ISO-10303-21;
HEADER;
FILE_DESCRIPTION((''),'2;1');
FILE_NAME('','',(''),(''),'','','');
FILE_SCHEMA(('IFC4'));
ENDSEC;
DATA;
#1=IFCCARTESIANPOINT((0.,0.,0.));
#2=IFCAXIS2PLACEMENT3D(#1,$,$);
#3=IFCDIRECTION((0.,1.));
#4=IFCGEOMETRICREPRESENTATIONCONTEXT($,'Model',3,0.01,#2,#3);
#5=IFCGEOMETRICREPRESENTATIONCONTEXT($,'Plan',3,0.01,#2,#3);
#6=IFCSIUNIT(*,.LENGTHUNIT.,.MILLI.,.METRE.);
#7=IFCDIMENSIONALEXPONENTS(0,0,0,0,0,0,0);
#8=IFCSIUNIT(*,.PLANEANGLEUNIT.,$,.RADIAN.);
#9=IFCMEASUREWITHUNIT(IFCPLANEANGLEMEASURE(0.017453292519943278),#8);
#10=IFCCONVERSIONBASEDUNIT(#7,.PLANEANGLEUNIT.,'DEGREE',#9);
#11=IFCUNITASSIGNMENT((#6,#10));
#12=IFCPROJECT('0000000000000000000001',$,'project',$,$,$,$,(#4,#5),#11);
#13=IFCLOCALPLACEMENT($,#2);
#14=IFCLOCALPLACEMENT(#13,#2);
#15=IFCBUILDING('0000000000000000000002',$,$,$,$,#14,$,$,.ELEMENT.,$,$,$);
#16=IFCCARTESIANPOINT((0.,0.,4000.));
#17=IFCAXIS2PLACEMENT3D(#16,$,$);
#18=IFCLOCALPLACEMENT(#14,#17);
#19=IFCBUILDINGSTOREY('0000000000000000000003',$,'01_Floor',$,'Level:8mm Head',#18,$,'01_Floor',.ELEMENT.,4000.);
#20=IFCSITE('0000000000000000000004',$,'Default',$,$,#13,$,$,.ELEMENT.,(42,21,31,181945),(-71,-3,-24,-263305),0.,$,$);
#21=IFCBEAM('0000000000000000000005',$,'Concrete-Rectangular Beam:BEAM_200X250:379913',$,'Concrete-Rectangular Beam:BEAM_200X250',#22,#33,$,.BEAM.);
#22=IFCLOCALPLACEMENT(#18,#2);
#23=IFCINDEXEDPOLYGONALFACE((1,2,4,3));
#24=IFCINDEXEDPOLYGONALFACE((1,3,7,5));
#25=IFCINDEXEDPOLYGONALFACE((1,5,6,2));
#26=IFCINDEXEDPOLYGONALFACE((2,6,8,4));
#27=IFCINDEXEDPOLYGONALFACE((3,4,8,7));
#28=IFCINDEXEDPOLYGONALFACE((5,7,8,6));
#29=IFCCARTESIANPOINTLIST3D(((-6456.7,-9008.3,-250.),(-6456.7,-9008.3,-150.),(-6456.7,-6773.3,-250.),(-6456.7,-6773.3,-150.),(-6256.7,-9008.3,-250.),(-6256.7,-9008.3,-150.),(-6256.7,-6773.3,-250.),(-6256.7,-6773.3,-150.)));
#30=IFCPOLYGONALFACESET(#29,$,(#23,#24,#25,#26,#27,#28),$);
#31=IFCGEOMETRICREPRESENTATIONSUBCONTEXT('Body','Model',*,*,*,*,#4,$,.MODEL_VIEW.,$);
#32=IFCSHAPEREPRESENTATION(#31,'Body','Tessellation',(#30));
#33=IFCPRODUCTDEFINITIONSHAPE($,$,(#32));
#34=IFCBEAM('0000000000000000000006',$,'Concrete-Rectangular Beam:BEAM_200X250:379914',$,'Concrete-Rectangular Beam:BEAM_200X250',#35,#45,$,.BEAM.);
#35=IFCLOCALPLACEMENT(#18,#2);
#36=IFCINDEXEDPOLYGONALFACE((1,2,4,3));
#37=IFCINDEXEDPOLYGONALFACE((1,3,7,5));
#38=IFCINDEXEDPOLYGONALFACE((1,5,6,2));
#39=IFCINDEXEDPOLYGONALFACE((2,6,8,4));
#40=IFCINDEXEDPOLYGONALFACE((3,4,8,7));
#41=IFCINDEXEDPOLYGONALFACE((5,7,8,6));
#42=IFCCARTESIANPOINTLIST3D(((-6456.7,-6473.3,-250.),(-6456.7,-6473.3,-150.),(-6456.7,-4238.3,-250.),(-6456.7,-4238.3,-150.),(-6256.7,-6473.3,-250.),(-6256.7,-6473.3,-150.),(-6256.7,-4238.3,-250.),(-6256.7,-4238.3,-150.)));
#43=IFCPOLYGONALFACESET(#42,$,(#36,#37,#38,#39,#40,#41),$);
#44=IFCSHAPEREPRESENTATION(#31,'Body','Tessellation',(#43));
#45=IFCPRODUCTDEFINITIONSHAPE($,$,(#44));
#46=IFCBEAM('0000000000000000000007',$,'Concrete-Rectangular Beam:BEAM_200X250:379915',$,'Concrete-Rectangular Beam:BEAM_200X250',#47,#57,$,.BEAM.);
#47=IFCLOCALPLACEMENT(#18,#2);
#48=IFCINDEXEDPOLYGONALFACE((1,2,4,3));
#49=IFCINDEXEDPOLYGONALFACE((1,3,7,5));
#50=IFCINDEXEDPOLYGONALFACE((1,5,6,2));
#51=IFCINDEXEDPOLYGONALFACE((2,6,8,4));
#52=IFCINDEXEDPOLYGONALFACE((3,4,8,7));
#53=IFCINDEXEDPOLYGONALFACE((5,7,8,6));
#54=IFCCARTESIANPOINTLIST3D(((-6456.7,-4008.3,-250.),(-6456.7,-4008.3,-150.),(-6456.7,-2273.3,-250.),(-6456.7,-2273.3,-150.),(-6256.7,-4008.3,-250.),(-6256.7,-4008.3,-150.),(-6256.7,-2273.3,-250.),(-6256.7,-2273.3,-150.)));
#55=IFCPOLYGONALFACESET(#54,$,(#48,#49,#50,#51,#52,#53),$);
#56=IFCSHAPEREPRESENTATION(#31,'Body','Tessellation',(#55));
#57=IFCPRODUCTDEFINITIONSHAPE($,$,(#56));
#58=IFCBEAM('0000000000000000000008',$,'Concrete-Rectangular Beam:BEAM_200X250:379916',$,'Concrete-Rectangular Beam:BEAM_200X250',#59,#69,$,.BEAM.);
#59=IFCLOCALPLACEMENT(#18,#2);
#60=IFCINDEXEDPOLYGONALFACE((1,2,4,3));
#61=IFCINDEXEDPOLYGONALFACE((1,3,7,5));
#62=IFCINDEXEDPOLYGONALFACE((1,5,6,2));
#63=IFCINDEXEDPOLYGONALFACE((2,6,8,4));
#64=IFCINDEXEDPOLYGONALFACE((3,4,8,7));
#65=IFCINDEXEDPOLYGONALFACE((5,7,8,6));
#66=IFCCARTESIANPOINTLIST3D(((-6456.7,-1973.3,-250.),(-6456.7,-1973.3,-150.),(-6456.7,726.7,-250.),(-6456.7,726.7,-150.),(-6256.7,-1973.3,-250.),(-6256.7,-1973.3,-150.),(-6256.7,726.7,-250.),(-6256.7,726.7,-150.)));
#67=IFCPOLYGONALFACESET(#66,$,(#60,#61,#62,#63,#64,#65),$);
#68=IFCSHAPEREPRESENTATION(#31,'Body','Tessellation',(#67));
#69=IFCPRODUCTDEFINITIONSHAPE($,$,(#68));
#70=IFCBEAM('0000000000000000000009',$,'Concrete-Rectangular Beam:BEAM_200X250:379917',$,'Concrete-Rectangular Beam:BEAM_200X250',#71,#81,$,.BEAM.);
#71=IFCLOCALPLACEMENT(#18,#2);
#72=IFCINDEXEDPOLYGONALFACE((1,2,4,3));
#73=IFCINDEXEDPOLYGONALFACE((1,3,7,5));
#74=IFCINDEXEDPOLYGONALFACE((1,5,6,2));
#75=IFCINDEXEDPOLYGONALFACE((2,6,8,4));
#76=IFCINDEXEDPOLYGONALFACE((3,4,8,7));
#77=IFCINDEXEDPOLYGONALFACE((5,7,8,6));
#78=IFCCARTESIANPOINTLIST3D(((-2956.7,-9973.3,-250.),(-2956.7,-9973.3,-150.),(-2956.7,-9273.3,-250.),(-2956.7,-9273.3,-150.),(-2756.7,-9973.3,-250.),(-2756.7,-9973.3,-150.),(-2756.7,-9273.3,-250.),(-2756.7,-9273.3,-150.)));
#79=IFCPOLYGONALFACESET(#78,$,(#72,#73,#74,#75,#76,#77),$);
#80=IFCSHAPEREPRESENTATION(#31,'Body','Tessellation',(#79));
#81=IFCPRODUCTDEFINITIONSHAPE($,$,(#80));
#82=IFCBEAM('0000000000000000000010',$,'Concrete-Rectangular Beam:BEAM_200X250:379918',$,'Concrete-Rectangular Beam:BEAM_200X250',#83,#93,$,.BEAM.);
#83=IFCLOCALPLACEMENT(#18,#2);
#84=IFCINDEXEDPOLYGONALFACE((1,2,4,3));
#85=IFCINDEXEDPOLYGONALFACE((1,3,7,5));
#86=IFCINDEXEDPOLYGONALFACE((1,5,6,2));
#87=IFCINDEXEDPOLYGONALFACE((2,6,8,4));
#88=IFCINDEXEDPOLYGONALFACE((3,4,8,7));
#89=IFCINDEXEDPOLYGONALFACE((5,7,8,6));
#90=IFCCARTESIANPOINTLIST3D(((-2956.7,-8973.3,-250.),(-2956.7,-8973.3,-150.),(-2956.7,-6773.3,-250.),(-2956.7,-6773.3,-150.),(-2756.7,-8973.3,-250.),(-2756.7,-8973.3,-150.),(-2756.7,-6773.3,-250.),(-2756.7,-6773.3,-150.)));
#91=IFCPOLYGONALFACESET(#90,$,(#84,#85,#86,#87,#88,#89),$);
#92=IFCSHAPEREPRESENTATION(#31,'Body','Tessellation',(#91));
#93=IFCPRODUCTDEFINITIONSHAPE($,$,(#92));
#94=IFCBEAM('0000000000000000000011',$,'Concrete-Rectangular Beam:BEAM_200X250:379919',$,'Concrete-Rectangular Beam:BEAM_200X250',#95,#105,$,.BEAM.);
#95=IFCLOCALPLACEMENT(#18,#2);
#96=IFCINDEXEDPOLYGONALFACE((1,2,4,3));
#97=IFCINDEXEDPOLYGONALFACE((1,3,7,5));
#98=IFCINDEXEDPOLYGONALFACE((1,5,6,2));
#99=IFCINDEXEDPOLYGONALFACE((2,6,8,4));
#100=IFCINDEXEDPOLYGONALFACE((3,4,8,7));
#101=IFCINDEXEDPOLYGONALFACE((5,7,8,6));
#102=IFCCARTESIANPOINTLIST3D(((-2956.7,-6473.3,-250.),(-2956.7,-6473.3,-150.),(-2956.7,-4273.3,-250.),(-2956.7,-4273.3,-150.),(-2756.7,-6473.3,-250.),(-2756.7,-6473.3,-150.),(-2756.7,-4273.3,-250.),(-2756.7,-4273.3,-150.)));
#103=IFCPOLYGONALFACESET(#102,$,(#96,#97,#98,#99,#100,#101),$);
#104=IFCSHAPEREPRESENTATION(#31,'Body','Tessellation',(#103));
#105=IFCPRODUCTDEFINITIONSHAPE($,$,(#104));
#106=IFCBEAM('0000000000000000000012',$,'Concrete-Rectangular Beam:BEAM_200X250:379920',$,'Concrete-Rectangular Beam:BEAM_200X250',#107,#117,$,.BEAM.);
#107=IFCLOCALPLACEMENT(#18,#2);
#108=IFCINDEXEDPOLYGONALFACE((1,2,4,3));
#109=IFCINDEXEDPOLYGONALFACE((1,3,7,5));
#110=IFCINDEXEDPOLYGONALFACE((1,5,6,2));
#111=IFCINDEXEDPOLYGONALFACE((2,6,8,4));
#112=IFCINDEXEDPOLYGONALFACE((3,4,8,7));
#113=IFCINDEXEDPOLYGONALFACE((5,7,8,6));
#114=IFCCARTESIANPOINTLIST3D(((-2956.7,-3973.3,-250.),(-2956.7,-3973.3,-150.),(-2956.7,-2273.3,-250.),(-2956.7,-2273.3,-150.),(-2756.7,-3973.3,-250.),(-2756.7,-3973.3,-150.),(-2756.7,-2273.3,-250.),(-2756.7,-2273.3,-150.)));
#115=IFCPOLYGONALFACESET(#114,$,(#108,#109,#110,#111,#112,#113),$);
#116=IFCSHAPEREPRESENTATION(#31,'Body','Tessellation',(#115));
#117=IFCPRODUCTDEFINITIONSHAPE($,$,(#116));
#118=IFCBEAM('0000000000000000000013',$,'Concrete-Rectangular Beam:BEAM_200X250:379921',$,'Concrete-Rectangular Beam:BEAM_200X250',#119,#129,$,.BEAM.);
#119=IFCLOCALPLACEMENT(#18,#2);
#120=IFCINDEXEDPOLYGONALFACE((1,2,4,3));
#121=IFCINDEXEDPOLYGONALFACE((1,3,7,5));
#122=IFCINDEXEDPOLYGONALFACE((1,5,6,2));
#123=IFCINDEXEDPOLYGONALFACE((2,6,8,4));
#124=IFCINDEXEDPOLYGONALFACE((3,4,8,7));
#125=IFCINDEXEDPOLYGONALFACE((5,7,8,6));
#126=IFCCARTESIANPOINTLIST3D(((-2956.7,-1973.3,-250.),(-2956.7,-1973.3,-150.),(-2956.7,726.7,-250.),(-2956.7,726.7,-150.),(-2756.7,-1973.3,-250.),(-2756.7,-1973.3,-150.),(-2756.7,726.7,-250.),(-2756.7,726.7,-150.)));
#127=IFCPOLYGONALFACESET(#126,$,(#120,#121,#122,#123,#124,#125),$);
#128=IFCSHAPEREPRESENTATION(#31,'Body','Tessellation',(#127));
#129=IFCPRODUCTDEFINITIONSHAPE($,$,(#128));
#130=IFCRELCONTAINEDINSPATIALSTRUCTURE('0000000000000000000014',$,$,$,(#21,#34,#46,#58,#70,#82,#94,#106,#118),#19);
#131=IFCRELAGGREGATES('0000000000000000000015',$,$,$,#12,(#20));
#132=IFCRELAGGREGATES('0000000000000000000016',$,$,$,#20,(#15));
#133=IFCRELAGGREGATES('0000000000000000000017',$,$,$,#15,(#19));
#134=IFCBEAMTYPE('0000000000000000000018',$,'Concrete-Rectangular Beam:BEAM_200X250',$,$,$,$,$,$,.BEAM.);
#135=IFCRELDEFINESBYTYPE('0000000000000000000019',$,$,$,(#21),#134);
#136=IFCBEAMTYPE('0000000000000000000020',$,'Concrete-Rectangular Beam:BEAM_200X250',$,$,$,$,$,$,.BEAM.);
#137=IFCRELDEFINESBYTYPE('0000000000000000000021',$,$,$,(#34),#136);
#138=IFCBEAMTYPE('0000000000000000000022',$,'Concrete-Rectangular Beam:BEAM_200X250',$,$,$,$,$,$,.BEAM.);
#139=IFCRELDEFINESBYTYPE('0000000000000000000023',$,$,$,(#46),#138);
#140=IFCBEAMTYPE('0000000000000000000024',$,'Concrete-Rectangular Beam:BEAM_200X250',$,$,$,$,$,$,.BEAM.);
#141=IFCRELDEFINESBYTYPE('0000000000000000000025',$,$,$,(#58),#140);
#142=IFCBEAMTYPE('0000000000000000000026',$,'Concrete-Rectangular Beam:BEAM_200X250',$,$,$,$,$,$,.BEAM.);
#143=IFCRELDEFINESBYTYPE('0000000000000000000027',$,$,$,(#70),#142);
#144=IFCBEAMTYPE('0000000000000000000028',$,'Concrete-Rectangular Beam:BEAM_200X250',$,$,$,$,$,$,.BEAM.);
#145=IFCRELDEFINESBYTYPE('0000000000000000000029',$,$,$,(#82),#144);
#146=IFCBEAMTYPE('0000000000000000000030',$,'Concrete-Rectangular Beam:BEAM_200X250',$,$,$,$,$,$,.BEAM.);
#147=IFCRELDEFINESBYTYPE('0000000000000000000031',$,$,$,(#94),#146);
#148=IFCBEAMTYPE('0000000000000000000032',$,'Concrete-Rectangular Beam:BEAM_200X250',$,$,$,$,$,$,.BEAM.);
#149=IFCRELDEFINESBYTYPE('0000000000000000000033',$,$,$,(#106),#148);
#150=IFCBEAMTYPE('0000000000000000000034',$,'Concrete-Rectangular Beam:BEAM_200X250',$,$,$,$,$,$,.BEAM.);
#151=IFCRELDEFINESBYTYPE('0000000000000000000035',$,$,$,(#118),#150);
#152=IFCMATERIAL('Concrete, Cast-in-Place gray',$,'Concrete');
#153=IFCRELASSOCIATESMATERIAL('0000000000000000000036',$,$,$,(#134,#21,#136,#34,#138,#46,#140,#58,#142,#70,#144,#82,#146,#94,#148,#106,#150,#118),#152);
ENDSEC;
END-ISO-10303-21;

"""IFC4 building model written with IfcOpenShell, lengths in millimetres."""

from ifc_helpers import new_model, entity, si_unit, converted_unit, direction, frame, origin, place, context, subcontext, project, spatial, indexed_curve, outline, extrude, source, transform, mapped, material, type_object, type_shapes, element, save


model = new_model("IFC4")

# Units and contexts
model_context = context("Model", 3, precision=0.01, world=origin(), true_north=direction((0.0, 1.0)))
plan_context = context("Plan", 3, precision=0.01, world=origin(), true_north=direction((0.0, 1.0)))
body_context = subcontext(model_context, "Body", "Model", "MODEL_VIEW")
ifc_project = project(units=[si_unit("LENGTHUNIT", "METRE", prefix="MILLI"), converted_unit("PLANEANGLEUNIT", "DEGREE", entity("IfcPlaneAngleMeasure", 0.017453292519943278), si_unit("PLANEANGLEUNIT", "RADIAN"), dimensions=[0, 0, 0, 0, 0, 0, 0])], contexts=[model_context, plan_context])

# Site, building, storey
site_placement = place(None, origin())
site = spatial("IfcSite", under=ifc_project, at=site_placement, Name="Default", CompositionType="ELEMENT", RefLatitude=(42, 21, 31, 181945), RefLongitude=(-71, -3, -24, -263305), RefElevation=0.0)
building_placement = place(site_placement, origin())
building = spatial("IfcBuilding", under=site, at=building_placement, CompositionType="ELEMENT")
storey_placement = place(building_placement, frame((0.0, 0.0, 4000.0)))
storey = spatial("IfcBuildingStorey", under=building, at=storey_placement, Name="01_Floor", ObjectType="Level:8mm Head", LongName="01_Floor", CompositionType="ELEMENT", Elevation=4000.0)

# Shared definitions
ifc_material = material(Name="Concrete, Cast-in-Place gray", Category="Concrete")

# Beams
beam_type_1 = type_object("IfcBeamType", Name="Concrete-Rectangular Beam:BEAM_200X250", PredefinedType="BEAM", material=ifc_material)
shared_shape_1 = source(origin(), body_context, "Body", "SweptSolid", [
    extrude(outline(indexed_curve([(-100.0, -50.0), (100.0, -50.0), (100.0, 50.0), (-100.0, 50.0), (-100.0, -50.0)], self_intersect=False)), frame((-6356.7, -9008.3, 3800.0), z_axis=(0.0, 1.0, 0.0), x_axis=(-1.0, 0.0, 0.0)), (0.0, 0.0, 1.0), 2235.0),
])
type_shapes(beam_type_1, [shared_shape_1])
beam_1_placement = place(storey_placement, frame((0.0, 0.0, -4000.0)))
element("IfcBeam", 1, at=beam_1_placement, inside=storey, type_object=beam_type_1, material=ifc_material, Name="Concrete-Rectangular Beam:BEAM_200X250:379913", ObjectType="Concrete-Rectangular Beam:BEAM_200X250", PredefinedType="BEAM", context=body_context, shape_type="MappedRepresentation", body=[
    mapped(shared_shape_1, transform((0.0, 0.0, 0.0), scale=1.0)),
])
beam_type_2 = type_object("IfcBeamType", Name="Concrete-Rectangular Beam:BEAM_200X250", PredefinedType="BEAM", material=ifc_material)
shared_shape_2 = source(origin(), body_context, "Body", "SweptSolid", [
    extrude(outline(indexed_curve([(-100.0, -50.0), (100.0, -50.0), (100.0, 50.0), (-100.0, 50.0), (-100.0, -50.0)], self_intersect=False)), frame((-6356.7, -6473.3, 3800.0), z_axis=(0.0, 1.0, 0.0), x_axis=(-1.0, 0.0, 0.0)), (0.0, 0.0, 1.0), 2235.0),
])
type_shapes(beam_type_2, [shared_shape_2])
beam_2_placement = place(storey_placement, frame((0.0, 0.0, -4000.0)))
element("IfcBeam", 2, at=beam_2_placement, inside=storey, type_object=beam_type_2, material=ifc_material, Name="Concrete-Rectangular Beam:BEAM_200X250:379914", ObjectType="Concrete-Rectangular Beam:BEAM_200X250", PredefinedType="BEAM", context=body_context, shape_type="MappedRepresentation", body=[
    mapped(shared_shape_2, transform((0.0, 0.0, 0.0), scale=1.0)),
])
beam_type_3 = type_object("IfcBeamType", Name="Concrete-Rectangular Beam:BEAM_200X250", PredefinedType="BEAM", material=ifc_material)
shared_shape_3 = source(origin(), body_context, "Body", "SweptSolid", [
    extrude(outline(indexed_curve([(-100.0, -50.0), (100.0, -50.0), (100.0, 50.0), (-100.0, 50.0), (-100.0, -50.0)], self_intersect=False)), frame((-6356.7, -4008.3, 3800.0), z_axis=(0.0, 1.0, 0.0), x_axis=(-1.0, 0.0, 0.0)), (0.0, 0.0, 1.0), 1735.0),
])
type_shapes(beam_type_3, [shared_shape_3])
beam_3_placement = place(storey_placement, frame((0.0, 0.0, -4000.0)))
element("IfcBeam", 3, at=beam_3_placement, inside=storey, type_object=beam_type_3, material=ifc_material, Name="Concrete-Rectangular Beam:BEAM_200X250:379915", ObjectType="Concrete-Rectangular Beam:BEAM_200X250", PredefinedType="BEAM", context=body_context, shape_type="MappedRepresentation", body=[
    mapped(shared_shape_3, transform((0.0, 0.0, 0.0), scale=1.0)),
])
beam_type_4 = type_object("IfcBeamType", Name="Concrete-Rectangular Beam:BEAM_200X250", PredefinedType="BEAM", material=ifc_material)
shared_shape_4 = source(origin(), body_context, "Body", "SweptSolid", [
    extrude(outline(indexed_curve([(-100.0, -50.0), (100.0, -50.0), (100.0, 50.0), (-100.0, 50.0), (-100.0, -50.0)], self_intersect=False)), frame((-6356.7, -1973.3, 3800.0), z_axis=(0.0, 1.0, 0.0), x_axis=(-1.0, 0.0, 0.0)), (0.0, 0.0, 1.0), 2700.0),
])
type_shapes(beam_type_4, [shared_shape_4])
beam_4_placement = place(storey_placement, frame((0.0, 0.0, -4000.0)))
element("IfcBeam", 4, at=beam_4_placement, inside=storey, type_object=beam_type_4, material=ifc_material, Name="Concrete-Rectangular Beam:BEAM_200X250:379916", ObjectType="Concrete-Rectangular Beam:BEAM_200X250", PredefinedType="BEAM", context=body_context, shape_type="MappedRepresentation", body=[
    mapped(shared_shape_4, transform((0.0, 0.0, 0.0), scale=1.0)),
])
beam_type_5 = type_object("IfcBeamType", Name="Concrete-Rectangular Beam:BEAM_200X250", PredefinedType="BEAM", material=ifc_material)
shared_shape_5 = source(origin(), body_context, "Body", "SweptSolid", [
    extrude(outline(indexed_curve([(-100.0, -50.0), (100.0, -50.0), (100.0, 50.0), (-100.0, 50.0), (-100.0, -50.0)], self_intersect=False)), frame((-2856.7, -9973.3, 3800.0), z_axis=(0.0, 1.0, 0.0), x_axis=(-1.0, 0.0, 0.0)), (0.0, 0.0, 1.0), 700.0),
])
type_shapes(beam_type_5, [shared_shape_5])
beam_5_placement = place(storey_placement, frame((0.0, 0.0, -4000.0)))
element("IfcBeam", 5, at=beam_5_placement, inside=storey, type_object=beam_type_5, material=ifc_material, Name="Concrete-Rectangular Beam:BEAM_200X250:379917", ObjectType="Concrete-Rectangular Beam:BEAM_200X250", PredefinedType="BEAM", context=body_context, shape_type="MappedRepresentation", body=[
    mapped(shared_shape_5, transform((0.0, 0.0, 0.0), scale=1.0)),
])
beam_type_6 = type_object("IfcBeamType", Name="Concrete-Rectangular Beam:BEAM_200X250", PredefinedType="BEAM", material=ifc_material)
shared_shape_6 = source(origin(), body_context, "Body", "SweptSolid", [
    extrude(outline(indexed_curve([(-100.0, -50.0), (100.0, -50.0), (100.0, 50.0), (-100.0, 50.0), (-100.0, -50.0)], self_intersect=False)), frame((-2856.7, -8973.3, 3800.0), z_axis=(0.0, 1.0, 0.0), x_axis=(-1.0, 0.0, 0.0)), (0.0, 0.0, 1.0), 2200.0),
])
type_shapes(beam_type_6, [shared_shape_6])
beam_6_placement = place(storey_placement, frame((0.0, 0.0, -4000.0)))
element("IfcBeam", 6, at=beam_6_placement, inside=storey, type_object=beam_type_6, material=ifc_material, Name="Concrete-Rectangular Beam:BEAM_200X250:379918", ObjectType="Concrete-Rectangular Beam:BEAM_200X250", PredefinedType="BEAM", context=body_context, shape_type="MappedRepresentation", body=[
    mapped(shared_shape_6, transform((0.0, 0.0, 0.0), scale=1.0)),
])
beam_type_7 = type_object("IfcBeamType", Name="Concrete-Rectangular Beam:BEAM_200X250", PredefinedType="BEAM", material=ifc_material)
shared_shape_7 = source(origin(), body_context, "Body", "SweptSolid", [
    extrude(outline(indexed_curve([(-100.0, -50.0), (100.0, -50.0), (100.0, 50.0), (-100.0, 50.0), (-100.0, -50.0)], self_intersect=False)), frame((-2856.7, -6473.3, 3800.0), z_axis=(0.0, 1.0, 0.0), x_axis=(-1.0, 0.0, 0.0)), (0.0, 0.0, 1.0), 2200.0),
])
type_shapes(beam_type_7, [shared_shape_7])
beam_7_placement = place(storey_placement, frame((0.0, 0.0, -4000.0)))
element("IfcBeam", 7, at=beam_7_placement, inside=storey, type_object=beam_type_7, material=ifc_material, Name="Concrete-Rectangular Beam:BEAM_200X250:379919", ObjectType="Concrete-Rectangular Beam:BEAM_200X250", PredefinedType="BEAM", context=body_context, shape_type="MappedRepresentation", body=[
    mapped(shared_shape_7, transform((0.0, 0.0, 0.0), scale=1.0)),
])
beam_type_8 = type_object("IfcBeamType", Name="Concrete-Rectangular Beam:BEAM_200X250", PredefinedType="BEAM", material=ifc_material)
shared_shape_8 = source(origin(), body_context, "Body", "SweptSolid", [
    extrude(outline(indexed_curve([(-100.0, -50.0), (100.0, -50.0), (100.0, 50.0), (-100.0, 50.0), (-100.0, -50.0)], self_intersect=False)), frame((-2856.7, -3973.3, 3800.0), z_axis=(0.0, 1.0, 0.0), x_axis=(-1.0, 0.0, 0.0)), (0.0, 0.0, 1.0), 1700.0),
])
type_shapes(beam_type_8, [shared_shape_8])
beam_8_placement = place(storey_placement, frame((0.0, 0.0, -4000.0)))
element("IfcBeam", 8, at=beam_8_placement, inside=storey, type_object=beam_type_8, material=ifc_material, Name="Concrete-Rectangular Beam:BEAM_200X250:379920", ObjectType="Concrete-Rectangular Beam:BEAM_200X250", PredefinedType="BEAM", context=body_context, shape_type="MappedRepresentation", body=[
    mapped(shared_shape_8, transform((0.0, 0.0, 0.0), scale=1.0)),
])
beam_type_9 = type_object("IfcBeamType", Name="Concrete-Rectangular Beam:BEAM_200X250", PredefinedType="BEAM", material=ifc_material)
shared_shape_9 = source(origin(), body_context, "Body", "SweptSolid", [
    extrude(outline(indexed_curve([(-100.0, -50.0), (100.0, -50.0), (100.0, 50.0), (-100.0, 50.0), (-100.0, -50.0)], self_intersect=False)), frame((-2856.7, -1973.3, 3800.0), z_axis=(0.0, 1.0, 0.0), x_axis=(-1.0, 0.0, 0.0)), (0.0, 0.0, 1.0), 2700.0),
])
type_shapes(beam_type_9, [shared_shape_9])
beam_9_placement = place(storey_placement, frame((0.0, 0.0, -4000.0)))
element("IfcBeam", 9, at=beam_9_placement, inside=storey, type_object=beam_type_9, material=ifc_material, Name="Concrete-Rectangular Beam:BEAM_200X250:379921", ObjectType="Concrete-Rectangular Beam:BEAM_200X250", PredefinedType="BEAM", context=body_context, shape_type="MappedRepresentation", body=[
    mapped(shared_shape_9, transform((0.0, 0.0, 0.0), scale=1.0)),
])

save(model, "model.ifc")
